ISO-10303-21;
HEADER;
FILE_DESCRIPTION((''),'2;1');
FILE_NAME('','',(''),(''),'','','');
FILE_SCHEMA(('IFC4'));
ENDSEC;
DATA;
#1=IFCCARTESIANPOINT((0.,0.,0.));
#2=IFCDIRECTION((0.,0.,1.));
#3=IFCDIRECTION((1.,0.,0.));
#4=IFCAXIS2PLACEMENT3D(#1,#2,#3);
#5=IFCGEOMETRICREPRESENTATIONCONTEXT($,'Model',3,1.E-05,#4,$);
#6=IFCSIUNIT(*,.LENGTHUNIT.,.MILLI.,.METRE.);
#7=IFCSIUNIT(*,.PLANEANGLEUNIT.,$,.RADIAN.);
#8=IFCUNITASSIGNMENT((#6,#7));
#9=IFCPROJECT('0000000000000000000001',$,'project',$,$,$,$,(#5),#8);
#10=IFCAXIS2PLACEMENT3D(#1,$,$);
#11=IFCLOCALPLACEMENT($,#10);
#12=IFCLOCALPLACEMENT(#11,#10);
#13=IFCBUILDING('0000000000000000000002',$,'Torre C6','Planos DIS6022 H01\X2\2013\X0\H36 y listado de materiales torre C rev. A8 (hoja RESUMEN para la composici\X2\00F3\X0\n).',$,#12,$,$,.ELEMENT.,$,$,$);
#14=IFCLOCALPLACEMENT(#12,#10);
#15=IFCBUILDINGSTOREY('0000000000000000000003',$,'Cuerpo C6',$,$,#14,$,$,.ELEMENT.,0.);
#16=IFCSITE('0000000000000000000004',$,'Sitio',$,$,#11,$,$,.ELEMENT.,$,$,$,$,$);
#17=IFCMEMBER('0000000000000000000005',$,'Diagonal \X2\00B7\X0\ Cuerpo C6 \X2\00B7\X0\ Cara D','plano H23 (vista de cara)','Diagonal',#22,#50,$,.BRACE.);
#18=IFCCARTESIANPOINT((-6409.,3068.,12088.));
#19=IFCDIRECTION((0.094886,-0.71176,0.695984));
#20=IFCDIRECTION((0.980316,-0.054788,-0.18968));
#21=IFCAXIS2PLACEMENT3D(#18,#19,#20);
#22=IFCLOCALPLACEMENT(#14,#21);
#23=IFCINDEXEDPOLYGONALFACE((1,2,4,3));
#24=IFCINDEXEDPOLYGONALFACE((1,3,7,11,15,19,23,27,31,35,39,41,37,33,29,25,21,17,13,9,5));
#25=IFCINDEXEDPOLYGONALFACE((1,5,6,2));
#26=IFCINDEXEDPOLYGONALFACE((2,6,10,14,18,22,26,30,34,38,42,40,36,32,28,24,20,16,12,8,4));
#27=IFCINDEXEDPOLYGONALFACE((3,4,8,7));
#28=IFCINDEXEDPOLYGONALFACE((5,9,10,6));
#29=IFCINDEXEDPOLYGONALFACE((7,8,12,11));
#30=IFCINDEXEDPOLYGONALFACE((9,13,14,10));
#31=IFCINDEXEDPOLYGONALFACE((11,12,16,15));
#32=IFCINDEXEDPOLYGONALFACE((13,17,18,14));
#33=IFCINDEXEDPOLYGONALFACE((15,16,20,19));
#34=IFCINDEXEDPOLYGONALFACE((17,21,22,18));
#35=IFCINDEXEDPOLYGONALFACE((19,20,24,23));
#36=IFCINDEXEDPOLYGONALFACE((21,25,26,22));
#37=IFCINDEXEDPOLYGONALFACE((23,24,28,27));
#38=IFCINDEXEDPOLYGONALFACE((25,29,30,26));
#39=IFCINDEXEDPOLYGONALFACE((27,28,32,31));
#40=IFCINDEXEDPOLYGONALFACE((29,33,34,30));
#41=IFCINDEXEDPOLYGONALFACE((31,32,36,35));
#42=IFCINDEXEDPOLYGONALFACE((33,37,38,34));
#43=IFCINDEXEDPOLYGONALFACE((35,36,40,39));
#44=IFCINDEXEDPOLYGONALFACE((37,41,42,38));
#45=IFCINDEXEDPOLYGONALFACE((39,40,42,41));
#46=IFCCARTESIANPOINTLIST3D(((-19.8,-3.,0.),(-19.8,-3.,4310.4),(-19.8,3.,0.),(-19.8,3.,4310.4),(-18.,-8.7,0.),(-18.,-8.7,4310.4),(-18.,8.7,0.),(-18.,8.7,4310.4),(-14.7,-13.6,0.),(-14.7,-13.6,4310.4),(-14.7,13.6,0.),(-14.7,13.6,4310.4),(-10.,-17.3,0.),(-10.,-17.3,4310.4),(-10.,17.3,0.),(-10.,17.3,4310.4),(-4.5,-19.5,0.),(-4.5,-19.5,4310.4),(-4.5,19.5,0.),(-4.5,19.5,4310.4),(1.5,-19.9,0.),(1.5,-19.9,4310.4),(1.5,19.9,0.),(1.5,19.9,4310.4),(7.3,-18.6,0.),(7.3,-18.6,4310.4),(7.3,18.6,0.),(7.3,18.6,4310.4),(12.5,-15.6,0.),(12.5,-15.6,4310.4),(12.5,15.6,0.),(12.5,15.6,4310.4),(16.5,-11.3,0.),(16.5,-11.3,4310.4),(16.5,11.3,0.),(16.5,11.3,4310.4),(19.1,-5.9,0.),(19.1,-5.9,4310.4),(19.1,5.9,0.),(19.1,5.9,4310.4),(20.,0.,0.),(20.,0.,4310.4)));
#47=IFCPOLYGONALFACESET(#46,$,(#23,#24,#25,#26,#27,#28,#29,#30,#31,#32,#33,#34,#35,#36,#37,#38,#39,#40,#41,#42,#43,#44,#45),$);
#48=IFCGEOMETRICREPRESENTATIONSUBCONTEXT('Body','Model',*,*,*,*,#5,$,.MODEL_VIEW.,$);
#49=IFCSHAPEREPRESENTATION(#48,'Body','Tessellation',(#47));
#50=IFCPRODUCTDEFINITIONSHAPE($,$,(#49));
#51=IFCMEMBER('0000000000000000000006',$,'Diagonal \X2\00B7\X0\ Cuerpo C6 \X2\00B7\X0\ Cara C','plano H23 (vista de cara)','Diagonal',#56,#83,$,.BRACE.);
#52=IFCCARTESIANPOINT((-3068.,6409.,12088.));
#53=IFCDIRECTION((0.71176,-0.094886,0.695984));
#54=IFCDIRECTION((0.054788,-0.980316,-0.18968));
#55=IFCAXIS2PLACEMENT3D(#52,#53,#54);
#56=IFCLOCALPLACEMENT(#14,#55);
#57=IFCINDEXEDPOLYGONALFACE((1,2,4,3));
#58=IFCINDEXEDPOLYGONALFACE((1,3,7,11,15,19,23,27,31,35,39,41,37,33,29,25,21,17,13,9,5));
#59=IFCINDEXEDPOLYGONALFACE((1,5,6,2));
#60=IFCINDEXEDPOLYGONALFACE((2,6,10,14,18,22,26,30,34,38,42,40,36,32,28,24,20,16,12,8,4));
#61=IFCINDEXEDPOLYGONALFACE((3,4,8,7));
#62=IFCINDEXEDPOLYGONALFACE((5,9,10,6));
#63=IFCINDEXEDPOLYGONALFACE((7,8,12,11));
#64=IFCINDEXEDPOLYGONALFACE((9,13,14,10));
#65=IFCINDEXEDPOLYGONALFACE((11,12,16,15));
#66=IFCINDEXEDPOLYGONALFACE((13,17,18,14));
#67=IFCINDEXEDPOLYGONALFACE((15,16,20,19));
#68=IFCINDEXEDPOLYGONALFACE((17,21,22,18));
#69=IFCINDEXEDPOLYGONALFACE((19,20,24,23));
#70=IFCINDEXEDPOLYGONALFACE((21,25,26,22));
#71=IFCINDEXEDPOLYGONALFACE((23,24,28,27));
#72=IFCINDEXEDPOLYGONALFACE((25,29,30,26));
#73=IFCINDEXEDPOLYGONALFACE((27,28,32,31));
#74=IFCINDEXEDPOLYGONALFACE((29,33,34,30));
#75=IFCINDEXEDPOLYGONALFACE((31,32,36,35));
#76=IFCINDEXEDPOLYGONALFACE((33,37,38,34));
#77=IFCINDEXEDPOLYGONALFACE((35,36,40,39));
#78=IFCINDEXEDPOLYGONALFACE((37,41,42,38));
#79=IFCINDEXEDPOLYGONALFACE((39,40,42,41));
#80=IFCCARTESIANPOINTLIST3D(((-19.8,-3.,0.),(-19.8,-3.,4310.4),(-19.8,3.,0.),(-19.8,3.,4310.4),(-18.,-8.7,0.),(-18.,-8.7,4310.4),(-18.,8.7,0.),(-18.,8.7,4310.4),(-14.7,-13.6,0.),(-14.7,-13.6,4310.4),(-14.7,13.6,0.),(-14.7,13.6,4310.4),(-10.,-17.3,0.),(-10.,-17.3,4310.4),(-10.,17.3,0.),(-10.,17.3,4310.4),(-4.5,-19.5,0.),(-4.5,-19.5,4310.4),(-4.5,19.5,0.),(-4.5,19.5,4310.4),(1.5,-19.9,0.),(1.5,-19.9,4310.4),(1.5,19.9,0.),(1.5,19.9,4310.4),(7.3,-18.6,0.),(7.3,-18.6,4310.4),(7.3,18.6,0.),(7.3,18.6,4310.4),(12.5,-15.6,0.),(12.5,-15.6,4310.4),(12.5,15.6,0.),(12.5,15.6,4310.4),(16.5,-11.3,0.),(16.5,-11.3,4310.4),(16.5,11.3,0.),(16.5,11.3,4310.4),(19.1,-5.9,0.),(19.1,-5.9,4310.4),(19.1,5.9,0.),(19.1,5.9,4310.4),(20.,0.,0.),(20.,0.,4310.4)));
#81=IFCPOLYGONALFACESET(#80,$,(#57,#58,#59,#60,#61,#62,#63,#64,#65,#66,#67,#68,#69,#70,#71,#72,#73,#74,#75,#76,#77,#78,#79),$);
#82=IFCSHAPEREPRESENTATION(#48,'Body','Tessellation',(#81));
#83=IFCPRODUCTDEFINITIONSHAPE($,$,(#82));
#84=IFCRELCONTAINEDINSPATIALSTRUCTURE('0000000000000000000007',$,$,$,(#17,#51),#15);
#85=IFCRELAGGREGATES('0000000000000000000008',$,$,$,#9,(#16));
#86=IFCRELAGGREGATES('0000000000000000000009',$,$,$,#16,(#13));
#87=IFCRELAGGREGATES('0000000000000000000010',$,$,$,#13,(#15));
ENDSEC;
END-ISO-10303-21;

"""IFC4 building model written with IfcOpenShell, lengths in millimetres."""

from ifc_helpers import new_model, si_unit, frame, origin, origin_with_axes, place, context, subcontext, project, spatial, circle, extrude, element, save


model = new_model("IFC4")

# Units and contexts
model_context = context("Model", 3, precision=1e-05, world=origin_with_axes())
body_context = subcontext(model_context, "Body", "Model", "MODEL_VIEW")
ifc_project = project(units=[si_unit("LENGTHUNIT", "METRE", prefix="MILLI"), si_unit("PLANEANGLEUNIT", "RADIAN")], contexts=[model_context])

# Site, building, storey
site_placement = place(None, origin())
site = spatial("IfcSite", under=ifc_project, at=site_placement, Name="Sitio", CompositionType="ELEMENT")
building_placement = place(site_placement, origin())
building = spatial("IfcBuilding", under=site, at=building_placement, Name="Torre C6", Description="Planos DIS6022 H01–H36 y listado de materiales torre C rev. A8 (hoja RESUMEN para la composición).", CompositionType="ELEMENT")
storey_placement = place(building_placement, origin())
storey = spatial("IfcBuildingStorey", under=building, at=storey_placement, Name="Cuerpo C6", CompositionType="ELEMENT", Elevation=0.0)

# Members
member_1_placement = place(storey_placement, frame((-6409.0, 3068.0, 12088.0), z_axis=(0.094886, -0.71176, 0.695984), x_axis=(0.980316, -0.054788, -0.18968)))
element("IfcMember", 1, at=member_1_placement, inside=storey, Name="Diagonal · Cuerpo C6 · Cara D", Description="plano H23 (vista de cara)", ObjectType="Diagonal", PredefinedType="BRACE", context=body_context, shape_type="SweptSolid", body=[
    extrude(circle(Radius=20.0), None, (0.0, 0.0, 1.0), 4310.4),
])
member_2_placement = place(storey_placement, frame((-3068.0, 6409.0, 12088.0), z_axis=(0.71176, -0.094886, 0.695984), x_axis=(0.054788, -0.980316, -0.18968)))
element("IfcMember", 2, at=member_2_placement, inside=storey, Name="Diagonal · Cuerpo C6 · Cara C", Description="plano H23 (vista de cara)", ObjectType="Diagonal", PredefinedType="BRACE", context=body_context, shape_type="SweptSolid", body=[
    extrude(circle(Radius=20.0), None, (0.0, 0.0, 1.0), 4310.4),
])

save(model, "model.ifc")
